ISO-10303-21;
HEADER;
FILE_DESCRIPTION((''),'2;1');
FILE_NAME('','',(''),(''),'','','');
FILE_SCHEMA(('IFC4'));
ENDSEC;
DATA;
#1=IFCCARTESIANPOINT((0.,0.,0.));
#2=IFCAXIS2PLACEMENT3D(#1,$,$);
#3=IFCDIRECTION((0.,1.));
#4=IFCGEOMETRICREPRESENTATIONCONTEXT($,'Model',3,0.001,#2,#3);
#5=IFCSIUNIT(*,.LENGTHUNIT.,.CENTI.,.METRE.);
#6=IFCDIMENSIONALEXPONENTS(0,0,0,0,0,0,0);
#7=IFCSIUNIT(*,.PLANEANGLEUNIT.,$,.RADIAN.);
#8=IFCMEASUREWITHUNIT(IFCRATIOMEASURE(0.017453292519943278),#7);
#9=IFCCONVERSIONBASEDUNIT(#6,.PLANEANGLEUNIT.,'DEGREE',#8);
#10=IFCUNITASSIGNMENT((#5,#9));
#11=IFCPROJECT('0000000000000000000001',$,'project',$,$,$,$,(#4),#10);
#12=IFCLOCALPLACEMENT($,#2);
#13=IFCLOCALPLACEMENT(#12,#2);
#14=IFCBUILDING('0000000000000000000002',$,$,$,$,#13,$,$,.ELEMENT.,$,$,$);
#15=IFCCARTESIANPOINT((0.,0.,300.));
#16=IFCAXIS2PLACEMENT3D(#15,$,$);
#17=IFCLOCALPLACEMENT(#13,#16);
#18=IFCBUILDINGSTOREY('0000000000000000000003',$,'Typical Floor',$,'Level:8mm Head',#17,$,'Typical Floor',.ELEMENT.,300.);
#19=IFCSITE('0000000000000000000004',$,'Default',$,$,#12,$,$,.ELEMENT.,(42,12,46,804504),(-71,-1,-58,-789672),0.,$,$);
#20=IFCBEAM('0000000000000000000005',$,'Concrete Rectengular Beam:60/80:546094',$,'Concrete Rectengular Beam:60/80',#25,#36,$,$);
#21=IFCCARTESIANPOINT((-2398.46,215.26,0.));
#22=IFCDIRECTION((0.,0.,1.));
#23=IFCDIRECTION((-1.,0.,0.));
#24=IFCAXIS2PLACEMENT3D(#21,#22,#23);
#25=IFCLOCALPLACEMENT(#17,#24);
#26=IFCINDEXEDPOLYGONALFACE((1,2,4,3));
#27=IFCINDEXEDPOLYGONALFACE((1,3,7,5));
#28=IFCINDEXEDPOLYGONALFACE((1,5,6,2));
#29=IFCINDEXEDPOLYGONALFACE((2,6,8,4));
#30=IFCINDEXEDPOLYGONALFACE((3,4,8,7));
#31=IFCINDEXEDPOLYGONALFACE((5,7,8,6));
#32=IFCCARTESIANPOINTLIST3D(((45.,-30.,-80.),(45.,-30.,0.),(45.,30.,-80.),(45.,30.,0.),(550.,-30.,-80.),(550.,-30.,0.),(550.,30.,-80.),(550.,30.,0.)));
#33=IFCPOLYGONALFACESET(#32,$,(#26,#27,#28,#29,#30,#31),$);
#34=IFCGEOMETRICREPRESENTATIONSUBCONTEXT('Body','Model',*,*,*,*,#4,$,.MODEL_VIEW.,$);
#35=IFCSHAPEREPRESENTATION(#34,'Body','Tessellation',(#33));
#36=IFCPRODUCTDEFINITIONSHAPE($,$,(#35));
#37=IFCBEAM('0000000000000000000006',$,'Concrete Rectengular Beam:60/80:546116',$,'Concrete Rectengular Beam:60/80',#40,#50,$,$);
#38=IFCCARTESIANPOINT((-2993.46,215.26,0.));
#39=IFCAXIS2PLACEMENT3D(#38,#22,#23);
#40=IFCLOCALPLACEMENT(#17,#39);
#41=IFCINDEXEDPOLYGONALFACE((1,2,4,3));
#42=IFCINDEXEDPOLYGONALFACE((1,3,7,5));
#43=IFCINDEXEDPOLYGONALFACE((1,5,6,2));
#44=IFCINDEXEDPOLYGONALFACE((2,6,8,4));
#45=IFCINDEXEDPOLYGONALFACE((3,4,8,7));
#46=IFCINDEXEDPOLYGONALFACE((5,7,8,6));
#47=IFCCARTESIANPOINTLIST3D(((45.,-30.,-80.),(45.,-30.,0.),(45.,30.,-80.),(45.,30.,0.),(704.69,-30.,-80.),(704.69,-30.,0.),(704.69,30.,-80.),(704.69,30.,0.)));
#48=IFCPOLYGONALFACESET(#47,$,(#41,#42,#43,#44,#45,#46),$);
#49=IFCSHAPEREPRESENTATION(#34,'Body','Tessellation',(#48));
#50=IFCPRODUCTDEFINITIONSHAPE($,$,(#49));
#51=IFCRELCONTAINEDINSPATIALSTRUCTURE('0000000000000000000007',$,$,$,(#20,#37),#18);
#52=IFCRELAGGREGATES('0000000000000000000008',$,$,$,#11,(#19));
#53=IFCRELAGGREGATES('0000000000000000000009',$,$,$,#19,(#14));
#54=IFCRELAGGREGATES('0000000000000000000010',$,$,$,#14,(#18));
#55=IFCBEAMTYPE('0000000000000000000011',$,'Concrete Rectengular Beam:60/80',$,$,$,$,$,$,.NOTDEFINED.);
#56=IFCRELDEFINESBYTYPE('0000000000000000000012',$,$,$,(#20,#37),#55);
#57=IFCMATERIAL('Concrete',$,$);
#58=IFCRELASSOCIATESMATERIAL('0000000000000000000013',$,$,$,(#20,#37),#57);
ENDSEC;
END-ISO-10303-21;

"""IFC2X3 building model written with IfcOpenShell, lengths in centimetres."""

from ifc_helpers import new_model, entity, si_unit, converted_unit, direction, frame, frame_2d, origin, place, context, subcontext, project, spatial, rectangle, extrude, material, type_object, element, save


model = new_model("IFC2X3")

# Units and contexts
model_context = context("Model", 3, precision=0.001, world=origin(), true_north=direction((0.0, 1.0)))
body_context = subcontext(model_context, "Body", "Model", "MODEL_VIEW")
ifc_project = project(units=[si_unit("LENGTHUNIT", "METRE", prefix="CENTI"), converted_unit("PLANEANGLEUNIT", "DEGREE", entity("IfcRatioMeasure", 0.017453292519943278), si_unit("PLANEANGLEUNIT", "RADIAN"), dimensions=[0, 0, 0, 0, 0, 0, 0])], contexts=[model_context])

# Site, building, storey
site_placement = place(None, origin())
site = spatial("IfcSite", under=ifc_project, at=site_placement, Name="Default", CompositionType="ELEMENT", RefLatitude=(42, 12, 46, 804504), RefLongitude=(-71, -1, -58, -789672), RefElevation=0.0)
building_placement = place(site_placement, origin())
building = spatial("IfcBuilding", under=site, at=building_placement, CompositionType="ELEMENT")
storey_placement = place(building_placement, frame((0.0, 0.0, 300.0)))
storey = spatial("IfcBuildingStorey", under=building, at=storey_placement, Name="Typical Floor", ObjectType="Level:8mm Head", LongName="Typical Floor", CompositionType="ELEMENT", Elevation=300.0)

# Beams
ifc_material = material(Name="Concrete")
beam_type_1 = type_object("IfcBeamType", Name="Concrete Rectengular Beam:60/80", PredefinedType="NOTDEFINED")
beam_1_placement = place(storey_placement, frame((-2398.46, 215.26, 0.0), z_axis=(0.0, 0.0, 1.0), x_axis=(-1.0, 0.0, 0.0)))
element("IfcBeam", 1, at=beam_1_placement, inside=storey, type_object=beam_type_1, material=ifc_material, Name="Concrete Rectengular Beam:60/80:546094", ObjectType="Concrete Rectengular Beam:60/80", context=body_context, shape_type="SweptSolid", body=[
    extrude(rectangle(XDim=80.0, YDim=60.0, at=frame_2d((0.0, 0.0), x_axis=(1.0, 0.0))), frame((45.0, 0.0, -40.0), z_axis=(1.0, 0.0, 0.0), x_axis=(0.0, 0.0, -1.0)), (0.0, 0.0, 1.0), 505.0),
])
beam_2_placement = place(storey_placement, frame((-2993.46, 215.26, 0.0), z_axis=(0.0, 0.0, 1.0), x_axis=(-1.0, 0.0, 0.0)))
element("IfcBeam", 2, at=beam_2_placement, inside=storey, type_object=beam_type_1, material=ifc_material, Name="Concrete Rectengular Beam:60/80:546116", ObjectType="Concrete Rectengular Beam:60/80", context=body_context, shape_type="SweptSolid", body=[
    extrude(rectangle(XDim=80.0, YDim=60.0, at=frame_2d((0.0, 0.0), x_axis=(1.0, 0.0))), frame((45.0, 0.0, -40.0), z_axis=(1.0, 0.0, 0.0), x_axis=(0.0, 0.0, -1.0)), (0.0, 0.0, 1.0), 659.69),
])

save(model, "model.ifc")
